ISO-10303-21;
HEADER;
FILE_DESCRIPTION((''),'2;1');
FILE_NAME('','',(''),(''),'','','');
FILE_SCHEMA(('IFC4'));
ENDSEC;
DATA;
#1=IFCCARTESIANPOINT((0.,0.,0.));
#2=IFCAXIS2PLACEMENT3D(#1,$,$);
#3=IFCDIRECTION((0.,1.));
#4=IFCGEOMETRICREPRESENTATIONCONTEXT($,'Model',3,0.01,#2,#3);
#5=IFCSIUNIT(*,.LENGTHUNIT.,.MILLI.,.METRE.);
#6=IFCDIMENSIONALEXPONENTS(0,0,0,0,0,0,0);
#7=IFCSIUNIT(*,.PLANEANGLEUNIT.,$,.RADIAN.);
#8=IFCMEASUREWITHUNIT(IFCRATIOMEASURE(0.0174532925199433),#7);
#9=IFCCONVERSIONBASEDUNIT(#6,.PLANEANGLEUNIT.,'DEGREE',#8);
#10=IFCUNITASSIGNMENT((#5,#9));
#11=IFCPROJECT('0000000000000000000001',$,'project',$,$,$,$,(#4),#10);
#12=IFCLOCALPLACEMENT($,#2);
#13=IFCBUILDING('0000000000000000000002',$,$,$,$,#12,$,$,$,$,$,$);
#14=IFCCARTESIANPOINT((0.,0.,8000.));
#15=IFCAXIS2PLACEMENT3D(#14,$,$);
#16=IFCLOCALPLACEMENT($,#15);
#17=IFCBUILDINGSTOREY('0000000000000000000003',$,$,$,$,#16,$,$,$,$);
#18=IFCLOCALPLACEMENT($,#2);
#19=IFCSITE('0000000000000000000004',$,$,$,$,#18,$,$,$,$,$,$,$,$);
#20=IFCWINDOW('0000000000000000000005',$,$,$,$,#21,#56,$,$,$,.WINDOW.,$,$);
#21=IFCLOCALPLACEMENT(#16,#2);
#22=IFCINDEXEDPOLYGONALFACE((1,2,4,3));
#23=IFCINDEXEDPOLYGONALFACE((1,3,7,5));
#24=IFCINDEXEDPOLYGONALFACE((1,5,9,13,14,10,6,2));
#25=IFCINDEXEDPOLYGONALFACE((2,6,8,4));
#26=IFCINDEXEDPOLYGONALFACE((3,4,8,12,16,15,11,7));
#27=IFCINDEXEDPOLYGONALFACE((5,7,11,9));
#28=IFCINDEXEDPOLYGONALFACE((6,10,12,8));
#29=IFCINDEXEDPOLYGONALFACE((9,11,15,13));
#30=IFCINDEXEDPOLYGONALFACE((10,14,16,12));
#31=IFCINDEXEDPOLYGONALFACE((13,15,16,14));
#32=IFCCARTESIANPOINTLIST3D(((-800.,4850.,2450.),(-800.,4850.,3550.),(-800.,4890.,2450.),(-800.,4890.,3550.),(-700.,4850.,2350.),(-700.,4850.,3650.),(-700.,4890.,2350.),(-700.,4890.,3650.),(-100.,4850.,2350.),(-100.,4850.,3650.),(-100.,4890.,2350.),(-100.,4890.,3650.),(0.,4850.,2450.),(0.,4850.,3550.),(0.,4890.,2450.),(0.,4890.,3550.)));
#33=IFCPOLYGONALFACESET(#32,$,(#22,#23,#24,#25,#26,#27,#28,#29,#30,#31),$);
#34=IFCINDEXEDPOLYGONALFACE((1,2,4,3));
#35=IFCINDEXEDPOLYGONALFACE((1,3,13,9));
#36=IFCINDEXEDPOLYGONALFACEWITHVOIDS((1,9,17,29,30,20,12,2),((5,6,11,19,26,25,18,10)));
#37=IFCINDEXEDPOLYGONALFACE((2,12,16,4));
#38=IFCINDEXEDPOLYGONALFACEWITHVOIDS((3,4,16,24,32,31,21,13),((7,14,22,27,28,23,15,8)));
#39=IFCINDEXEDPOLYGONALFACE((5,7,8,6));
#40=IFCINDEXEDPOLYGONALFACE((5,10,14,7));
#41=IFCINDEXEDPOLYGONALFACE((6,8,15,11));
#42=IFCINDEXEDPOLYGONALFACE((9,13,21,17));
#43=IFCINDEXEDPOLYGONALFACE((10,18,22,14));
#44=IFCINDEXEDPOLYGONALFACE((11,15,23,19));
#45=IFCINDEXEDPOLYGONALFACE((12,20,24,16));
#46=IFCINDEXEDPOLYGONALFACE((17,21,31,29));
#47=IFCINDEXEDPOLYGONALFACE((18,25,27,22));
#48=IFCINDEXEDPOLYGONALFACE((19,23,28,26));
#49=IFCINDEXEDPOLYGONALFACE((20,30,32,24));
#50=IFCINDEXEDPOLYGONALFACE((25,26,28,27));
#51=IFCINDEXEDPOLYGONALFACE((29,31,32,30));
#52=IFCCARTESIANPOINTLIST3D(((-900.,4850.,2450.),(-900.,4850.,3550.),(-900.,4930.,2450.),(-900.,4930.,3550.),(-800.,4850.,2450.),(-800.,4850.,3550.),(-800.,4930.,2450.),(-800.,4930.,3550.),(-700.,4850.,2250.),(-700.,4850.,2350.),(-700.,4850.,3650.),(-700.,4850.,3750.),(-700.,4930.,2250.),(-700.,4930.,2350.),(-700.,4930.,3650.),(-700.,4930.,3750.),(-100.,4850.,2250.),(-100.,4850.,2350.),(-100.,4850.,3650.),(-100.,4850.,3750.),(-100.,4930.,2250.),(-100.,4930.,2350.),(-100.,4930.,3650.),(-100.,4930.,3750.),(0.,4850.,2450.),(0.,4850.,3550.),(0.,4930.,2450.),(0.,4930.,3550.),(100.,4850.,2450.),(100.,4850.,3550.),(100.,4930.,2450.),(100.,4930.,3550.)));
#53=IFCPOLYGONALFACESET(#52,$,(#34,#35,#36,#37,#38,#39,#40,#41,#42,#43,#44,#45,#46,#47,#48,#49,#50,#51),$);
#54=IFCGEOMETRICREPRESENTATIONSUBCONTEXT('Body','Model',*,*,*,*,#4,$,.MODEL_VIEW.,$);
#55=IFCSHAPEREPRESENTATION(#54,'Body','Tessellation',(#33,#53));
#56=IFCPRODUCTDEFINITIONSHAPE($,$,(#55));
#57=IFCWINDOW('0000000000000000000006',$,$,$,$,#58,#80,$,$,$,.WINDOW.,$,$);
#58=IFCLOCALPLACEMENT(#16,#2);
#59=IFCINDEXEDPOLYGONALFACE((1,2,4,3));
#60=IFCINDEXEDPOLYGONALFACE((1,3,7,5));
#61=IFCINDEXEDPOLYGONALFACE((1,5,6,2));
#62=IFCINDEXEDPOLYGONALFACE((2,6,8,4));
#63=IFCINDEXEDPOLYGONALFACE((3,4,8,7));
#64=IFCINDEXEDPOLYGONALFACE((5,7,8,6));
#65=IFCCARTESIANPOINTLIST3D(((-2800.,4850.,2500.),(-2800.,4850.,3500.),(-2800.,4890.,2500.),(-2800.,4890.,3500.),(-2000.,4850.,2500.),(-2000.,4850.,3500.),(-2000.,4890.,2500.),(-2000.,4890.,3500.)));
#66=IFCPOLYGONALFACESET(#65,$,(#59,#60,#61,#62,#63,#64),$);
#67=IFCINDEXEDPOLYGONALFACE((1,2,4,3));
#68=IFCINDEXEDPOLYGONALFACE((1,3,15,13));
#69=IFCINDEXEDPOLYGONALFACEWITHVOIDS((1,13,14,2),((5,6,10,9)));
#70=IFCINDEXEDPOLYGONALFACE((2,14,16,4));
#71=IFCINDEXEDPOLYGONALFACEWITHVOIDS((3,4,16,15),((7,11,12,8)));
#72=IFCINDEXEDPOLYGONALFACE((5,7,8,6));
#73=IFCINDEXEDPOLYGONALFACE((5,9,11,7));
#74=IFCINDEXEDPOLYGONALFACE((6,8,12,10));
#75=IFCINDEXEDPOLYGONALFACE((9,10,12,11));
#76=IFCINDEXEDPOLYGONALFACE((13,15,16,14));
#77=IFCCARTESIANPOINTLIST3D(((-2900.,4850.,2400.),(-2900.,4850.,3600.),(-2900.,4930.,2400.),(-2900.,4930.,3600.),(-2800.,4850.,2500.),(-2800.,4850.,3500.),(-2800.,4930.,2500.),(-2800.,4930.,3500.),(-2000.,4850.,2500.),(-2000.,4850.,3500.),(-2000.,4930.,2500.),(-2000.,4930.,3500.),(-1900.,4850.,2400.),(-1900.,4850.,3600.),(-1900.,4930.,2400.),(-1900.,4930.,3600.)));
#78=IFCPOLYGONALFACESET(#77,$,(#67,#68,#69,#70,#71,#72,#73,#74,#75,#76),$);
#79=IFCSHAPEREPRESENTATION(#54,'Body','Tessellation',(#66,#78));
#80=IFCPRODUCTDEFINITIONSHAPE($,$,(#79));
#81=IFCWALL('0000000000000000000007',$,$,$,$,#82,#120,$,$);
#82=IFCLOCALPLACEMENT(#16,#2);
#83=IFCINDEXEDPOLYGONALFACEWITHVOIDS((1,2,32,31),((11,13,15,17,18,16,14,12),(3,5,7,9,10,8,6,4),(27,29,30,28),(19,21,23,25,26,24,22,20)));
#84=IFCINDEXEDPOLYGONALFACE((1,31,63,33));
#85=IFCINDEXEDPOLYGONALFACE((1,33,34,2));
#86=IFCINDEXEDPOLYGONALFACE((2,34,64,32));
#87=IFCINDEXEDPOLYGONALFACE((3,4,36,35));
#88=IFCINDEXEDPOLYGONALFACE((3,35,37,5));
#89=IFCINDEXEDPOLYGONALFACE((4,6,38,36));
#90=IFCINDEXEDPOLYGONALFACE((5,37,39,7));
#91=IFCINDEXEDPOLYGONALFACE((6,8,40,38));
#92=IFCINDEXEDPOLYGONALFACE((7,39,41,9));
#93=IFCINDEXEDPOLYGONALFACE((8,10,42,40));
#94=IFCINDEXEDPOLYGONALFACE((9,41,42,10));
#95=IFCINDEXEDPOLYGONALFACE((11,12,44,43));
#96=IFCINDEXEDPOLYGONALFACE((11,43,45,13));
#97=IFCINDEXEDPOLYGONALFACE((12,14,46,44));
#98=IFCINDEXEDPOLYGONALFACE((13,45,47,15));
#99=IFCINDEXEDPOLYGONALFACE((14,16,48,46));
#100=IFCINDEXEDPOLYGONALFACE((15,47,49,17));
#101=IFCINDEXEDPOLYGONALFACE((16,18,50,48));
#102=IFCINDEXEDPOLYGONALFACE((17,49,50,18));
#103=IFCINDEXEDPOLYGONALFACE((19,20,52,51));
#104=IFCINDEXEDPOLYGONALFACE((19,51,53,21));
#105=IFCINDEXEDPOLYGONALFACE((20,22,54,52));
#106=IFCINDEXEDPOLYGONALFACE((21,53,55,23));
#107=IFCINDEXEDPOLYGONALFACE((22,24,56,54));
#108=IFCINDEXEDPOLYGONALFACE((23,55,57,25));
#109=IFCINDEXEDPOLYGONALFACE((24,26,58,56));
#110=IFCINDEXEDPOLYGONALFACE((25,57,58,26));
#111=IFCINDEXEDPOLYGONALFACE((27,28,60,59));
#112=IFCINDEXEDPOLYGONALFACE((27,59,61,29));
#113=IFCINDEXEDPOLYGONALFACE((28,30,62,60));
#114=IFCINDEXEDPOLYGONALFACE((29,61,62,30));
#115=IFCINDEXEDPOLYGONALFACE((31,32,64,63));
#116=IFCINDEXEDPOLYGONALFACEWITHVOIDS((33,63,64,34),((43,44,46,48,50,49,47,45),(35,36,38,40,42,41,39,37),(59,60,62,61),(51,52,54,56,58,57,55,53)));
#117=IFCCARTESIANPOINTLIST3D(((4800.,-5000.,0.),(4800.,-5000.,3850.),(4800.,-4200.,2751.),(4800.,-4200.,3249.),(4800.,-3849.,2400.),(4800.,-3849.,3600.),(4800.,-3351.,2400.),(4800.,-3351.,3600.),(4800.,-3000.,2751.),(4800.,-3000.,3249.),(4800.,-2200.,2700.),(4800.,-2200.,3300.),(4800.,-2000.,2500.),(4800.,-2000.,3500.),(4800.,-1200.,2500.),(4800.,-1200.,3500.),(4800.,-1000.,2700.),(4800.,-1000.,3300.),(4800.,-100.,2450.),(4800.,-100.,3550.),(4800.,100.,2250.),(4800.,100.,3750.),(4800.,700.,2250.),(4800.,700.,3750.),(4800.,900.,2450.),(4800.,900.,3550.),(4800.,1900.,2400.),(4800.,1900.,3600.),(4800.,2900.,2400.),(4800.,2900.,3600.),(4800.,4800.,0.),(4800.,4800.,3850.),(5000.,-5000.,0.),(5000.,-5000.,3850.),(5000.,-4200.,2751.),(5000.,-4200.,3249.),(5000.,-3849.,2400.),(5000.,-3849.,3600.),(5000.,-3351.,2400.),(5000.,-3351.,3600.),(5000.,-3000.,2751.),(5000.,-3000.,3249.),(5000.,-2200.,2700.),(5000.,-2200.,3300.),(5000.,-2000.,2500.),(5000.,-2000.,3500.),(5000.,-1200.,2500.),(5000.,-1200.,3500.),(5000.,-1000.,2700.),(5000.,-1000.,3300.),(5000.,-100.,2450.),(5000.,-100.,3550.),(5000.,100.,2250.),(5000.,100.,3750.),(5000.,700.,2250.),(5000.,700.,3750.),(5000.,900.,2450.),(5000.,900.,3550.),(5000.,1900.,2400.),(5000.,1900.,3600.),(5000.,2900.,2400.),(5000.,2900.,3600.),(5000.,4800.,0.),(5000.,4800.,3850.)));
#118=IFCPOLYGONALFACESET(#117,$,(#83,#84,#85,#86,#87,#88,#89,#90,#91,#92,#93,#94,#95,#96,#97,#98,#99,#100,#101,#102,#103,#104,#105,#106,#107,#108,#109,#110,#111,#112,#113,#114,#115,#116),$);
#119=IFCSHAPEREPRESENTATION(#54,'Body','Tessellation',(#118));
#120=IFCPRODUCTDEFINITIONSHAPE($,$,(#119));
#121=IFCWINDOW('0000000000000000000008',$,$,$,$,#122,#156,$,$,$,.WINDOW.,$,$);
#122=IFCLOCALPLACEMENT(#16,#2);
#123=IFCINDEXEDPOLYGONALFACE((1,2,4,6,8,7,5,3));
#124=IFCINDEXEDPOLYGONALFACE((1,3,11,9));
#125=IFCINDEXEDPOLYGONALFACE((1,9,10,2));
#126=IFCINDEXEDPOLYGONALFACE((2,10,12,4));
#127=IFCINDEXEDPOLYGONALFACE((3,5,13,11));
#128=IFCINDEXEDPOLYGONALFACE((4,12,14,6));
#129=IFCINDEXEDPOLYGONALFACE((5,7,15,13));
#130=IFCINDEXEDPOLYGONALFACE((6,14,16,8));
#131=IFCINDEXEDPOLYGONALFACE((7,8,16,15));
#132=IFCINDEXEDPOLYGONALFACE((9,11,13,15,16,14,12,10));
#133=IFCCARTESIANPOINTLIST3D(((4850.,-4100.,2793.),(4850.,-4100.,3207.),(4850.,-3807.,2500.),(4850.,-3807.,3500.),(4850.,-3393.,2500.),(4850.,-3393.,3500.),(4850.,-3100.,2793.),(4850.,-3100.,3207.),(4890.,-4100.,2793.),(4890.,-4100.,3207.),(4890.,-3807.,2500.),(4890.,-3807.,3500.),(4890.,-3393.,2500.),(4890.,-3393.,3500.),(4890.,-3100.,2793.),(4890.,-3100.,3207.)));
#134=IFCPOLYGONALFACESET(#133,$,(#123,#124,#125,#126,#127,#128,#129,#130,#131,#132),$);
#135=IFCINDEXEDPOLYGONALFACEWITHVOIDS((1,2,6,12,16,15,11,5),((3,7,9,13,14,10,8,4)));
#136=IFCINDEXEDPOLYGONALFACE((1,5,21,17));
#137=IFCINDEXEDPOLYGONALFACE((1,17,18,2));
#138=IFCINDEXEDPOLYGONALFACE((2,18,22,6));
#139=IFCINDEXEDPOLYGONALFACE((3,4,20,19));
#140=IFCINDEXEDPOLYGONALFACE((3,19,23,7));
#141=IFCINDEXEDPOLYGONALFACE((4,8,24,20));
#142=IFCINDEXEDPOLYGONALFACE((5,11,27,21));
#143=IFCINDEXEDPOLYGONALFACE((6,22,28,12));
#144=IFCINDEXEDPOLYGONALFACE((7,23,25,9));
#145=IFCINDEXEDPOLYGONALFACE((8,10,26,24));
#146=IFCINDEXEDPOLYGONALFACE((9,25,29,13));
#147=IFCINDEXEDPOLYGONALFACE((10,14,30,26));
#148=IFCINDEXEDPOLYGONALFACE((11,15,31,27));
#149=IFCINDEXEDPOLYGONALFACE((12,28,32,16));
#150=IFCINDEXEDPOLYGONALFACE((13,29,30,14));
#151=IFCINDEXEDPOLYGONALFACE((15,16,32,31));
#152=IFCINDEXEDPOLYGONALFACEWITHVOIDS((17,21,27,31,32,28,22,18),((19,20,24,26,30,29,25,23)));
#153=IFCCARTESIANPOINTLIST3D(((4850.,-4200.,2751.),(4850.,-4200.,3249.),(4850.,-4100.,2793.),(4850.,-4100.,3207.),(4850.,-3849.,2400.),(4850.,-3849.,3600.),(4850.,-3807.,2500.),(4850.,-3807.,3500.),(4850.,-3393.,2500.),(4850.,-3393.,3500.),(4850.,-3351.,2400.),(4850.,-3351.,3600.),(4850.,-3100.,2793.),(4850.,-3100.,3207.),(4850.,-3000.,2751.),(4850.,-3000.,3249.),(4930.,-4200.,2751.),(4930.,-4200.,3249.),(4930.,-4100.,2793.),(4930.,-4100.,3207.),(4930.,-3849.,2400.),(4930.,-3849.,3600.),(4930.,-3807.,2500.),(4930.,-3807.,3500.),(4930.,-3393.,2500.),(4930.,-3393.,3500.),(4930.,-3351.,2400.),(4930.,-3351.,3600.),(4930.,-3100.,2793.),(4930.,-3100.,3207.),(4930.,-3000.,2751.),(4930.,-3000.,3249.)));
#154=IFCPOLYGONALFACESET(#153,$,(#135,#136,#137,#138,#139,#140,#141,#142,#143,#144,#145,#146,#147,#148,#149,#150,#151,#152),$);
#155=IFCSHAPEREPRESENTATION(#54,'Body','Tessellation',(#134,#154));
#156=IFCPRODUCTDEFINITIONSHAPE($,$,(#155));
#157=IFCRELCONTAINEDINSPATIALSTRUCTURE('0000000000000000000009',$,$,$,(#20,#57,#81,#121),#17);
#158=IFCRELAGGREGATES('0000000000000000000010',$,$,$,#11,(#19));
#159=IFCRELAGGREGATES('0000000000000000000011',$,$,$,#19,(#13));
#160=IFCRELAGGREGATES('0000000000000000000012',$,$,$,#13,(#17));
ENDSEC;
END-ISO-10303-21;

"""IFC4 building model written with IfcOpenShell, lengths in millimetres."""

from ifc_helpers import new_model, entity, si_unit, converted_unit, direction, frame, origin, origin_2d, place, context, subcontext, project, spatial, polyline, rectangle, outline, extrude, element, save


model = new_model("IFC4")

# Units and contexts
model_context = context("Model", 3, precision=0.01, world=origin(), true_north=direction((0.0, 1.0)))
body_context = subcontext(model_context, "Body", "Model", "MODEL_VIEW")
ifc_project = project(units=[si_unit("LENGTHUNIT", "METRE", prefix="MILLI"), converted_unit("PLANEANGLEUNIT", "DEGREE", entity("IfcRatioMeasure", 0.0174532925199433), si_unit("PLANEANGLEUNIT", "RADIAN"), dimensions=[0, 0, 0, 0, 0, 0, 0])], contexts=[model_context])

# Site, building, storey
site_placement = place(None, origin())
site = spatial("IfcSite", under=ifc_project, at=site_placement)
building_placement = place(None, origin())
building = spatial("IfcBuilding", under=site, at=building_placement)
storey_placement = place(None, frame((0.0, 0.0, 8000.0)))
storey = spatial("IfcBuildingStorey", under=building, at=storey_placement)

# Shared definitions
wall_1_placement = place(storey_placement, frame((100.0, 4900.0, 0.0), z_axis=(0.0, 0.0, 1.0), x_axis=(-1.0, 0.0, 0.0)))
window_1_placement = place(wall_1_placement, frame((500.0, 50.0, 3000.0)))
window_2_placement = place(wall_1_placement, frame((2500.0, 50.0, 3000.0)))

# Windows
cartesian_point_1 = entity("IfcCartesianPoint", [-500.0, -207.0])
shared_polyline_1 = entity("IfcPolyline", [cartesian_point_1, entity("IfcCartesianPoint", [-500.0, 207.0]), entity("IfcCartesianPoint", [-207.0, 500.0]), entity("IfcCartesianPoint", [207.0, 500.0]), entity("IfcCartesianPoint", [500.0, 207.0]), entity("IfcCartesianPoint", [500.0, -207.0]), entity("IfcCartesianPoint", [207.0, -500.0]), entity("IfcCartesianPoint", [-207.0, -500.0]), cartesian_point_1])
cartesian_point_2 = entity("IfcCartesianPoint", [-400.0, -550.0])
shared_polyline_2 = entity("IfcPolyline", [cartesian_point_2, entity("IfcCartesianPoint", [-400.0, 550.0]), entity("IfcCartesianPoint", [-300.0, 650.0]), entity("IfcCartesianPoint", [300.0, 650.0]), entity("IfcCartesianPoint", [400.0, 550.0]), entity("IfcCartesianPoint", [400.0, -550.0]), entity("IfcCartesianPoint", [300.0, -650.0]), entity("IfcCartesianPoint", [-300.0, -650.0]), cartesian_point_2])
cartesian_point_3 = entity("IfcCartesianPoint", [-500.0, -550.0])
element("IfcWindow", 1, at=window_1_placement, inside=storey, PredefinedType="WINDOW", context=body_context, shape_type="SweptSolid", body=[
    entity("IfcExtrudedAreaSolid", entity("IfcArbitraryClosedProfileDef", "AREA", None, shared_polyline_2), entity("IfcAxis2Placement3D", entity("IfcCartesianPoint", [0.0, 0.0, 0.0]), entity("IfcDirection", [0.0, -1.0, 0.0]), entity("IfcDirection", [1.0, 0.0, 0.0])), entity("IfcDirection", [0.0, 0.0, 1.0]), 40.0),
    entity("IfcExtrudedAreaSolid", entity("IfcArbitraryProfileDefWithVoids", "AREA", None, entity("IfcPolyline", [cartesian_point_3, entity("IfcCartesianPoint", [-500.0, 550.0]), entity("IfcCartesianPoint", [-300.0, 750.0]), entity("IfcCartesianPoint", [300.0, 750.0]), entity("IfcCartesianPoint", [500.0, 550.0]), entity("IfcCartesianPoint", [500.0, -550.0]), entity("IfcCartesianPoint", [300.0, -750.0]), entity("IfcCartesianPoint", [-300.0, -750.0]), cartesian_point_3]), [shared_polyline_2]), entity("IfcAxis2Placement3D", entity("IfcCartesianPoint", [0.0, 0.0, 0.0]), entity("IfcDirection", [0.0, -1.0, 0.0]), entity("IfcDirection", [1.0, 0.0, 0.0])), entity("IfcDirection", [0.0, 0.0, 1.0]), 80.0),
])
cartesian_point_4 = entity("IfcCartesianPoint", [-400.0, -500.0])
shared_polyline_3 = entity("IfcPolyline", [cartesian_point_4, entity("IfcCartesianPoint", [-400.0, 500.0]), entity("IfcCartesianPoint", [-400.0, 500.0]), entity("IfcCartesianPoint", [400.0, 500.0]), entity("IfcCartesianPoint", [400.0, 500.0]), entity("IfcCartesianPoint", [400.0, -500.0]), entity("IfcCartesianPoint", [400.0, -500.0]), entity("IfcCartesianPoint", [-400.0, -500.0]), cartesian_point_4])
cartesian_point_5 = entity("IfcCartesianPoint", [-500.0, -600.0])
element("IfcWindow", 2, at=window_2_placement, inside=storey, PredefinedType="WINDOW", context=body_context, shape_type="SweptSolid", body=[
    entity("IfcExtrudedAreaSolid", entity("IfcArbitraryClosedProfileDef", "AREA", None, shared_polyline_3), entity("IfcAxis2Placement3D", entity("IfcCartesianPoint", [0.0, 0.0, 0.0]), entity("IfcDirection", [0.0, -1.0, 0.0]), entity("IfcDirection", [1.0, 0.0, 0.0])), entity("IfcDirection", [0.0, 0.0, 1.0]), 40.0),
    entity("IfcExtrudedAreaSolid", entity("IfcArbitraryProfileDefWithVoids", "AREA", None, entity("IfcPolyline", [cartesian_point_5, entity("IfcCartesianPoint", [-500.0, 600.0]), entity("IfcCartesianPoint", [-500.0, 600.0]), entity("IfcCartesianPoint", [500.0, 600.0]), entity("IfcCartesianPoint", [500.0, 600.0]), entity("IfcCartesianPoint", [500.0, -600.0]), entity("IfcCartesianPoint", [500.0, -600.0]), entity("IfcCartesianPoint", [-500.0, -600.0]), cartesian_point_5]), [shared_polyline_3]), entity("IfcAxis2Placement3D", entity("IfcCartesianPoint", [0.0, 0.0, 0.0]), entity("IfcDirection", [0.0, -1.0, 0.0]), entity("IfcDirection", [1.0, 0.0, 0.0])), entity("IfcDirection", [0.0, 0.0, 1.0]), 80.0),
])

# Wall, openings
wall_2_placement = place(storey_placement, frame((4900.0, -100.0, 0.0), z_axis=(0.0, 0.0, 1.0), x_axis=(0.0, 1.0, 0.0)))
wall_2 = element("IfcWall", 3, at=wall_2_placement, inside=storey, context=body_context, shape_type="SweptSolid", body=[
    extrude(rectangle(XDim=9800.0, YDim=200.0, at=origin_2d()), origin(), (0.0, 0.0, 1.0), 3850.0),
])
window_3_placement = place(wall_2_placement, frame((-3500.0, 50.0, 3000.0)))
opening_1_placement = place(window_3_placement, frame((0.0, 50.0, 0.0)))
element("IfcOpeningElement", 4, at=opening_1_placement, cuts=wall_2, context=body_context, shape_type="SweptSolid", body=[
    extrude(outline(polyline([(-600.0, -249.0), (-600.0, 249.0), (-249.0, 600.0), (249.0, 600.0), (600.0, 249.0), (600.0, -249.0), (249.0, -600.0), (-249.0, -600.0), (-600.0, -249.0)])), frame((0.0, 0.0, 0.0), z_axis=(0.0, -1.0, 0.0), x_axis=(1.0, 0.0, 0.0)), (0.0, 0.0, 1.0), 200.0),
])
window_4_placement = place(wall_2_placement, frame((-1500.0, 50.0, 3000.0)))
opening_2_placement = place(window_4_placement, frame((0.0, 50.0, 0.0)))
element("IfcOpeningElement", 5, at=opening_2_placement, cuts=wall_2, context=body_context, shape_type="SweptSolid", body=[
    extrude(outline(polyline([(-600.0, -300.0), (-600.0, 300.0), (-400.0, 500.0), (400.0, 500.0), (600.0, 300.0), (600.0, -300.0), (400.0, -500.0), (-400.0, -500.0), (-600.0, -300.0)])), frame((0.0, 0.0, 0.0), z_axis=(0.0, -1.0, 0.0), x_axis=(1.0, 0.0, 0.0)), (0.0, 0.0, 1.0), 200.0),
])
window_5_placement = place(wall_2_placement, frame((500.0, 50.0, 3000.0)))
opening_3_placement = place(window_5_placement, frame((0.0, 50.0, 0.0)))
element("IfcOpeningElement", 6, at=opening_3_placement, cuts=wall_2, context=body_context, shape_type="SweptSolid", body=[
    extrude(outline(polyline([(-500.0, -550.0), (-500.0, 550.0), (-300.0, 750.0), (300.0, 750.0), (500.0, 550.0), (500.0, -550.0), (300.0, -750.0), (-300.0, -750.0), (-500.0, -550.0)])), frame((0.0, 0.0, 0.0), z_axis=(0.0, -1.0, 0.0), x_axis=(1.0, 0.0, 0.0)), (0.0, 0.0, 1.0), 200.0),
])
window_6_placement = place(wall_2_placement, frame((2500.0, 50.0, 3000.0)))
opening_4_placement = place(window_6_placement, frame((0.0, 50.0, 0.0)))
element("IfcOpeningElement", 7, at=opening_4_placement, cuts=wall_2, context=body_context, shape_type="SweptSolid", body=[
    extrude(outline(polyline([(-500.0, -600.0), (-500.0, 600.0), (-500.0, 600.0), (500.0, 600.0), (500.0, 600.0), (500.0, -600.0), (500.0, -600.0), (-500.0, -600.0), (-500.0, -600.0)])), frame((0.0, 0.0, 0.0), z_axis=(0.0, -1.0, 0.0), x_axis=(1.0, 0.0, 0.0)), (0.0, 0.0, 1.0), 200.0),
])

# Window
cartesian_point_6 = entity("IfcCartesianPoint", [-600.0, -249.0])
element("IfcWindow", 8, at=window_3_placement, inside=storey, PredefinedType="WINDOW", context=body_context, shape_type="SweptSolid", body=[
    entity("IfcExtrudedAreaSolid", entity("IfcArbitraryClosedProfileDef", "AREA", None, shared_polyline_1), entity("IfcAxis2Placement3D", entity("IfcCartesianPoint", [0.0, 0.0, 0.0]), entity("IfcDirection", [0.0, -1.0, 0.0]), entity("IfcDirection", [1.0, 0.0, 0.0])), entity("IfcDirection", [0.0, 0.0, 1.0]), 40.0),
    entity("IfcExtrudedAreaSolid", entity("IfcArbitraryProfileDefWithVoids", "AREA", None, entity("IfcPolyline", [cartesian_point_6, entity("IfcCartesianPoint", [-600.0, 249.0]), entity("IfcCartesianPoint", [-249.0, 600.0]), entity("IfcCartesianPoint", [249.0, 600.0]), entity("IfcCartesianPoint", [600.0, 249.0]), entity("IfcCartesianPoint", [600.0, -249.0]), entity("IfcCartesianPoint", [249.0, -600.0]), entity("IfcCartesianPoint", [-249.0, -600.0]), cartesian_point_6]), [shared_polyline_1]), entity("IfcAxis2Placement3D", entity("IfcCartesianPoint", [0.0, 0.0, 0.0]), entity("IfcDirection", [0.0, -1.0, 0.0]), entity("IfcDirection", [1.0, 0.0, 0.0])), entity("IfcDirection", [0.0, 0.0, 1.0]), 80.0),
])

save(model, "model.ifc")
